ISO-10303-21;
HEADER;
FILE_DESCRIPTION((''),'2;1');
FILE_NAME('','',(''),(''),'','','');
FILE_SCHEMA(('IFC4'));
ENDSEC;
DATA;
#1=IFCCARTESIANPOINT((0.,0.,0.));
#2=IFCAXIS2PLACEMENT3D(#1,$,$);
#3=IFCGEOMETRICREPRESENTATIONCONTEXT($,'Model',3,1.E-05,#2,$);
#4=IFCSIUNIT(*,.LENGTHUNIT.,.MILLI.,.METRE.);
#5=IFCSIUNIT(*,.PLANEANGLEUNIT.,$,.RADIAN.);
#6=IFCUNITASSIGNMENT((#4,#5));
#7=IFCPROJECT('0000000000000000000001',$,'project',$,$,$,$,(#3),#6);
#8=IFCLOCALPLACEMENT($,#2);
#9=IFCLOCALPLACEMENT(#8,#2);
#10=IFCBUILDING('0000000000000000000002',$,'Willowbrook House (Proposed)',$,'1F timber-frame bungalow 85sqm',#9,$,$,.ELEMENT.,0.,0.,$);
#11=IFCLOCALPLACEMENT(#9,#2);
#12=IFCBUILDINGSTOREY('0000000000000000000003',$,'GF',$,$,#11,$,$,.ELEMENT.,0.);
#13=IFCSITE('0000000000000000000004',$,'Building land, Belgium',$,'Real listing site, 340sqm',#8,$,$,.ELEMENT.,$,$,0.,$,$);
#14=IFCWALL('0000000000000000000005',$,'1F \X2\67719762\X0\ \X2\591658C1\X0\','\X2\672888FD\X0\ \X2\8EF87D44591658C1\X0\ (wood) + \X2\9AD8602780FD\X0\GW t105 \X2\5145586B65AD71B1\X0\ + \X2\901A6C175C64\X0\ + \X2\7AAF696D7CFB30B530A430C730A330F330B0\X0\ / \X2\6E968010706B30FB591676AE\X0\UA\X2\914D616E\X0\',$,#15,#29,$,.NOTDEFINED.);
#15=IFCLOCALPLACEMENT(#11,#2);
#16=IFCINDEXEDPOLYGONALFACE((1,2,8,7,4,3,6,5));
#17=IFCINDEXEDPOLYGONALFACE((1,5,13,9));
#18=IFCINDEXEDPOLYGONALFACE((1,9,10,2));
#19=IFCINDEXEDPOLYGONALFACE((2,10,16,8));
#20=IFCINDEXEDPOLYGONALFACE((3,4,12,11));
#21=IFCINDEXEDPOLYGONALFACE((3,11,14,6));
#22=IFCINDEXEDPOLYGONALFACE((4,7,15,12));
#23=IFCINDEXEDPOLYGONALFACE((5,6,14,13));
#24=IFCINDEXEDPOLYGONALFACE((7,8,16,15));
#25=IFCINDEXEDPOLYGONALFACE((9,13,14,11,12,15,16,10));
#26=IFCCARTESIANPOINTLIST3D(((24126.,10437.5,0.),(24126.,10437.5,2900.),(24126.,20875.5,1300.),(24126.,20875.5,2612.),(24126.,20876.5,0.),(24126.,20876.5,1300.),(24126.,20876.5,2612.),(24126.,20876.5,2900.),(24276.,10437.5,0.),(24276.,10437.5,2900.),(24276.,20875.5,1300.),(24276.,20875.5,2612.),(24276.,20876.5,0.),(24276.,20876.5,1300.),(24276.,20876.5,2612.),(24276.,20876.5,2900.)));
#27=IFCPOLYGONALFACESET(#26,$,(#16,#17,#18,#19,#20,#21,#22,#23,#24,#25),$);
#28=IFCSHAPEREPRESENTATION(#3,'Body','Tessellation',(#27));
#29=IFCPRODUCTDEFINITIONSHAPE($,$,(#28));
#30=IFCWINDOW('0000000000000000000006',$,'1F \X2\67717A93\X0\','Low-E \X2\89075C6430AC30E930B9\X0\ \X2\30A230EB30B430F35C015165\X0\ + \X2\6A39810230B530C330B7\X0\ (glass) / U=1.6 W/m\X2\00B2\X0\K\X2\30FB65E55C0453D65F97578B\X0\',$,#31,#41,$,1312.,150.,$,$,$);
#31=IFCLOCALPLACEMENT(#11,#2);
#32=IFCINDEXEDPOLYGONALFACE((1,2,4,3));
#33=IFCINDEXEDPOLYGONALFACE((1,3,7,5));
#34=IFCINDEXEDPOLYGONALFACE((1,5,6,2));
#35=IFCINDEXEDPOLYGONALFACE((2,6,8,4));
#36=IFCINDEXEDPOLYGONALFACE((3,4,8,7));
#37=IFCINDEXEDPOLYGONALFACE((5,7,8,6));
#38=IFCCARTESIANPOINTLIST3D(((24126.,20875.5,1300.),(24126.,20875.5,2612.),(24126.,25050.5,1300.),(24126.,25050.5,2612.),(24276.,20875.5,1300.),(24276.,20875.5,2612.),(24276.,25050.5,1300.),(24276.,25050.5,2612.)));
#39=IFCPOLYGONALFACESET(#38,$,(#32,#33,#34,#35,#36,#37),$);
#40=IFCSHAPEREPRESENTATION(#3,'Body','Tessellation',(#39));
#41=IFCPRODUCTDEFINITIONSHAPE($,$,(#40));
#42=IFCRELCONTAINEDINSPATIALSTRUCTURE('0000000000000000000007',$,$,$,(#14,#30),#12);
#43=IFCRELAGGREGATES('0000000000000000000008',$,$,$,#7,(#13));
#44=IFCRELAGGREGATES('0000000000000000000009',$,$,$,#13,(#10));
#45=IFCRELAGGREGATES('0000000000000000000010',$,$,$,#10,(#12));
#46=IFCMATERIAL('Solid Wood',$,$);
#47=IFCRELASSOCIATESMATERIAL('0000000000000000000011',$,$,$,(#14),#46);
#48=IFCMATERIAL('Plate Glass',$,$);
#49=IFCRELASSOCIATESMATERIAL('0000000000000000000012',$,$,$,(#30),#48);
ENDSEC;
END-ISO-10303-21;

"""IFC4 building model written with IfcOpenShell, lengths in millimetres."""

from ifc_helpers import new_model, si_unit, frame, frame_2d, origin, place, context, project, spatial, rectangle, extrude, material, element, fill, save


model = new_model("IFC4")

# Units and contexts
model_context = context("Model", 3, precision=1e-05, world=origin())
ifc_project = project(units=[si_unit("LENGTHUNIT", "METRE", prefix="MILLI"), si_unit("PLANEANGLEUNIT", "RADIAN")], contexts=[model_context])

# Site, building, storey
site_placement = place(None, origin())
site = spatial("IfcSite", under=ifc_project, at=site_placement, Name="Building land, Belgium", ObjectType="Real listing site, 340sqm", CompositionType="ELEMENT", RefElevation=0.0)
building_placement = place(site_placement, origin())
building = spatial("IfcBuilding", under=site, at=building_placement, Name="Willowbrook House (Proposed)", ObjectType="1F timber-frame bungalow 85sqm", CompositionType="ELEMENT", ElevationOfRefHeight=0.0, ElevationOfTerrain=0.0)
storey_placement = place(building_placement, origin())
storey = spatial("IfcBuildingStorey", under=building, at=storey_placement, Name="GF", CompositionType="ELEMENT", Elevation=0.0)

# Shared definitions
ifc_material_1 = material(Name="Solid Wood")

# Wall, opening, window
wall_1_placement = place(storey_placement, frame((12063.0, 5219.0, 0.0)))
wall_1 = element("IfcWall", 1, at=wall_1_placement, inside=storey, material=ifc_material_1, Name="1F 東面 外壁", Description="木製 軸組外壁 (wood) + 高性能GW t105 充填断熱 + 通気層 + 窯業系サイディング / 準耐火・外皮UA配慮", PredefinedType="NOTDEFINED", context=model_context, shape_type="SweptSolid", body=[
    extrude(rectangle(XDim=150.0, YDim=10439.0, at=frame_2d((75.0, 5219.0))), frame((12063.0, 5219.0, 0.0)), (0.0, 0.0, 1.0), 2900.0),
])
opening_placement = place(storey_placement, frame((12063.0, 10438.0, 650.0)))
opening = element("IfcOpeningElement", 2, at=opening_placement, cuts=wall_1, PredefinedType="NOTDEFINED", context=model_context, shape_type="SweptSolid", body=[
    extrude(rectangle(XDim=150.0, YDim=4175.0, at=frame_2d((75.0, 2087.0))), frame((12063.0, 10438.0, 650.0)), (0.0, 0.0, 1.0), 1312.0),
])
ifc_material_2 = material(Name="Plate Glass")
window_placement = place(storey_placement, frame((12063.0, 10438.0, 650.0)))
window = element("IfcWindow", 3, at=window_placement, inside=storey, material=ifc_material_2, Name="1F 東窓", Description="Low-E 複層ガラス アルゴン封入 + 樹脂サッシ (glass) / U=1.6 W/m²K・日射取得型", OverallHeight=1312.0, OverallWidth=150.0, context=model_context, shape_type="SweptSolid", body=[
    extrude(rectangle(XDim=150.0, YDim=4175.0, at=frame_2d((75.0, 2087.0))), frame((12063.0, 10438.0, 650.0)), (0.0, 0.0, 1.0), 1312.0),
])
fill(opening, window)

save(model, "model.ifc")
